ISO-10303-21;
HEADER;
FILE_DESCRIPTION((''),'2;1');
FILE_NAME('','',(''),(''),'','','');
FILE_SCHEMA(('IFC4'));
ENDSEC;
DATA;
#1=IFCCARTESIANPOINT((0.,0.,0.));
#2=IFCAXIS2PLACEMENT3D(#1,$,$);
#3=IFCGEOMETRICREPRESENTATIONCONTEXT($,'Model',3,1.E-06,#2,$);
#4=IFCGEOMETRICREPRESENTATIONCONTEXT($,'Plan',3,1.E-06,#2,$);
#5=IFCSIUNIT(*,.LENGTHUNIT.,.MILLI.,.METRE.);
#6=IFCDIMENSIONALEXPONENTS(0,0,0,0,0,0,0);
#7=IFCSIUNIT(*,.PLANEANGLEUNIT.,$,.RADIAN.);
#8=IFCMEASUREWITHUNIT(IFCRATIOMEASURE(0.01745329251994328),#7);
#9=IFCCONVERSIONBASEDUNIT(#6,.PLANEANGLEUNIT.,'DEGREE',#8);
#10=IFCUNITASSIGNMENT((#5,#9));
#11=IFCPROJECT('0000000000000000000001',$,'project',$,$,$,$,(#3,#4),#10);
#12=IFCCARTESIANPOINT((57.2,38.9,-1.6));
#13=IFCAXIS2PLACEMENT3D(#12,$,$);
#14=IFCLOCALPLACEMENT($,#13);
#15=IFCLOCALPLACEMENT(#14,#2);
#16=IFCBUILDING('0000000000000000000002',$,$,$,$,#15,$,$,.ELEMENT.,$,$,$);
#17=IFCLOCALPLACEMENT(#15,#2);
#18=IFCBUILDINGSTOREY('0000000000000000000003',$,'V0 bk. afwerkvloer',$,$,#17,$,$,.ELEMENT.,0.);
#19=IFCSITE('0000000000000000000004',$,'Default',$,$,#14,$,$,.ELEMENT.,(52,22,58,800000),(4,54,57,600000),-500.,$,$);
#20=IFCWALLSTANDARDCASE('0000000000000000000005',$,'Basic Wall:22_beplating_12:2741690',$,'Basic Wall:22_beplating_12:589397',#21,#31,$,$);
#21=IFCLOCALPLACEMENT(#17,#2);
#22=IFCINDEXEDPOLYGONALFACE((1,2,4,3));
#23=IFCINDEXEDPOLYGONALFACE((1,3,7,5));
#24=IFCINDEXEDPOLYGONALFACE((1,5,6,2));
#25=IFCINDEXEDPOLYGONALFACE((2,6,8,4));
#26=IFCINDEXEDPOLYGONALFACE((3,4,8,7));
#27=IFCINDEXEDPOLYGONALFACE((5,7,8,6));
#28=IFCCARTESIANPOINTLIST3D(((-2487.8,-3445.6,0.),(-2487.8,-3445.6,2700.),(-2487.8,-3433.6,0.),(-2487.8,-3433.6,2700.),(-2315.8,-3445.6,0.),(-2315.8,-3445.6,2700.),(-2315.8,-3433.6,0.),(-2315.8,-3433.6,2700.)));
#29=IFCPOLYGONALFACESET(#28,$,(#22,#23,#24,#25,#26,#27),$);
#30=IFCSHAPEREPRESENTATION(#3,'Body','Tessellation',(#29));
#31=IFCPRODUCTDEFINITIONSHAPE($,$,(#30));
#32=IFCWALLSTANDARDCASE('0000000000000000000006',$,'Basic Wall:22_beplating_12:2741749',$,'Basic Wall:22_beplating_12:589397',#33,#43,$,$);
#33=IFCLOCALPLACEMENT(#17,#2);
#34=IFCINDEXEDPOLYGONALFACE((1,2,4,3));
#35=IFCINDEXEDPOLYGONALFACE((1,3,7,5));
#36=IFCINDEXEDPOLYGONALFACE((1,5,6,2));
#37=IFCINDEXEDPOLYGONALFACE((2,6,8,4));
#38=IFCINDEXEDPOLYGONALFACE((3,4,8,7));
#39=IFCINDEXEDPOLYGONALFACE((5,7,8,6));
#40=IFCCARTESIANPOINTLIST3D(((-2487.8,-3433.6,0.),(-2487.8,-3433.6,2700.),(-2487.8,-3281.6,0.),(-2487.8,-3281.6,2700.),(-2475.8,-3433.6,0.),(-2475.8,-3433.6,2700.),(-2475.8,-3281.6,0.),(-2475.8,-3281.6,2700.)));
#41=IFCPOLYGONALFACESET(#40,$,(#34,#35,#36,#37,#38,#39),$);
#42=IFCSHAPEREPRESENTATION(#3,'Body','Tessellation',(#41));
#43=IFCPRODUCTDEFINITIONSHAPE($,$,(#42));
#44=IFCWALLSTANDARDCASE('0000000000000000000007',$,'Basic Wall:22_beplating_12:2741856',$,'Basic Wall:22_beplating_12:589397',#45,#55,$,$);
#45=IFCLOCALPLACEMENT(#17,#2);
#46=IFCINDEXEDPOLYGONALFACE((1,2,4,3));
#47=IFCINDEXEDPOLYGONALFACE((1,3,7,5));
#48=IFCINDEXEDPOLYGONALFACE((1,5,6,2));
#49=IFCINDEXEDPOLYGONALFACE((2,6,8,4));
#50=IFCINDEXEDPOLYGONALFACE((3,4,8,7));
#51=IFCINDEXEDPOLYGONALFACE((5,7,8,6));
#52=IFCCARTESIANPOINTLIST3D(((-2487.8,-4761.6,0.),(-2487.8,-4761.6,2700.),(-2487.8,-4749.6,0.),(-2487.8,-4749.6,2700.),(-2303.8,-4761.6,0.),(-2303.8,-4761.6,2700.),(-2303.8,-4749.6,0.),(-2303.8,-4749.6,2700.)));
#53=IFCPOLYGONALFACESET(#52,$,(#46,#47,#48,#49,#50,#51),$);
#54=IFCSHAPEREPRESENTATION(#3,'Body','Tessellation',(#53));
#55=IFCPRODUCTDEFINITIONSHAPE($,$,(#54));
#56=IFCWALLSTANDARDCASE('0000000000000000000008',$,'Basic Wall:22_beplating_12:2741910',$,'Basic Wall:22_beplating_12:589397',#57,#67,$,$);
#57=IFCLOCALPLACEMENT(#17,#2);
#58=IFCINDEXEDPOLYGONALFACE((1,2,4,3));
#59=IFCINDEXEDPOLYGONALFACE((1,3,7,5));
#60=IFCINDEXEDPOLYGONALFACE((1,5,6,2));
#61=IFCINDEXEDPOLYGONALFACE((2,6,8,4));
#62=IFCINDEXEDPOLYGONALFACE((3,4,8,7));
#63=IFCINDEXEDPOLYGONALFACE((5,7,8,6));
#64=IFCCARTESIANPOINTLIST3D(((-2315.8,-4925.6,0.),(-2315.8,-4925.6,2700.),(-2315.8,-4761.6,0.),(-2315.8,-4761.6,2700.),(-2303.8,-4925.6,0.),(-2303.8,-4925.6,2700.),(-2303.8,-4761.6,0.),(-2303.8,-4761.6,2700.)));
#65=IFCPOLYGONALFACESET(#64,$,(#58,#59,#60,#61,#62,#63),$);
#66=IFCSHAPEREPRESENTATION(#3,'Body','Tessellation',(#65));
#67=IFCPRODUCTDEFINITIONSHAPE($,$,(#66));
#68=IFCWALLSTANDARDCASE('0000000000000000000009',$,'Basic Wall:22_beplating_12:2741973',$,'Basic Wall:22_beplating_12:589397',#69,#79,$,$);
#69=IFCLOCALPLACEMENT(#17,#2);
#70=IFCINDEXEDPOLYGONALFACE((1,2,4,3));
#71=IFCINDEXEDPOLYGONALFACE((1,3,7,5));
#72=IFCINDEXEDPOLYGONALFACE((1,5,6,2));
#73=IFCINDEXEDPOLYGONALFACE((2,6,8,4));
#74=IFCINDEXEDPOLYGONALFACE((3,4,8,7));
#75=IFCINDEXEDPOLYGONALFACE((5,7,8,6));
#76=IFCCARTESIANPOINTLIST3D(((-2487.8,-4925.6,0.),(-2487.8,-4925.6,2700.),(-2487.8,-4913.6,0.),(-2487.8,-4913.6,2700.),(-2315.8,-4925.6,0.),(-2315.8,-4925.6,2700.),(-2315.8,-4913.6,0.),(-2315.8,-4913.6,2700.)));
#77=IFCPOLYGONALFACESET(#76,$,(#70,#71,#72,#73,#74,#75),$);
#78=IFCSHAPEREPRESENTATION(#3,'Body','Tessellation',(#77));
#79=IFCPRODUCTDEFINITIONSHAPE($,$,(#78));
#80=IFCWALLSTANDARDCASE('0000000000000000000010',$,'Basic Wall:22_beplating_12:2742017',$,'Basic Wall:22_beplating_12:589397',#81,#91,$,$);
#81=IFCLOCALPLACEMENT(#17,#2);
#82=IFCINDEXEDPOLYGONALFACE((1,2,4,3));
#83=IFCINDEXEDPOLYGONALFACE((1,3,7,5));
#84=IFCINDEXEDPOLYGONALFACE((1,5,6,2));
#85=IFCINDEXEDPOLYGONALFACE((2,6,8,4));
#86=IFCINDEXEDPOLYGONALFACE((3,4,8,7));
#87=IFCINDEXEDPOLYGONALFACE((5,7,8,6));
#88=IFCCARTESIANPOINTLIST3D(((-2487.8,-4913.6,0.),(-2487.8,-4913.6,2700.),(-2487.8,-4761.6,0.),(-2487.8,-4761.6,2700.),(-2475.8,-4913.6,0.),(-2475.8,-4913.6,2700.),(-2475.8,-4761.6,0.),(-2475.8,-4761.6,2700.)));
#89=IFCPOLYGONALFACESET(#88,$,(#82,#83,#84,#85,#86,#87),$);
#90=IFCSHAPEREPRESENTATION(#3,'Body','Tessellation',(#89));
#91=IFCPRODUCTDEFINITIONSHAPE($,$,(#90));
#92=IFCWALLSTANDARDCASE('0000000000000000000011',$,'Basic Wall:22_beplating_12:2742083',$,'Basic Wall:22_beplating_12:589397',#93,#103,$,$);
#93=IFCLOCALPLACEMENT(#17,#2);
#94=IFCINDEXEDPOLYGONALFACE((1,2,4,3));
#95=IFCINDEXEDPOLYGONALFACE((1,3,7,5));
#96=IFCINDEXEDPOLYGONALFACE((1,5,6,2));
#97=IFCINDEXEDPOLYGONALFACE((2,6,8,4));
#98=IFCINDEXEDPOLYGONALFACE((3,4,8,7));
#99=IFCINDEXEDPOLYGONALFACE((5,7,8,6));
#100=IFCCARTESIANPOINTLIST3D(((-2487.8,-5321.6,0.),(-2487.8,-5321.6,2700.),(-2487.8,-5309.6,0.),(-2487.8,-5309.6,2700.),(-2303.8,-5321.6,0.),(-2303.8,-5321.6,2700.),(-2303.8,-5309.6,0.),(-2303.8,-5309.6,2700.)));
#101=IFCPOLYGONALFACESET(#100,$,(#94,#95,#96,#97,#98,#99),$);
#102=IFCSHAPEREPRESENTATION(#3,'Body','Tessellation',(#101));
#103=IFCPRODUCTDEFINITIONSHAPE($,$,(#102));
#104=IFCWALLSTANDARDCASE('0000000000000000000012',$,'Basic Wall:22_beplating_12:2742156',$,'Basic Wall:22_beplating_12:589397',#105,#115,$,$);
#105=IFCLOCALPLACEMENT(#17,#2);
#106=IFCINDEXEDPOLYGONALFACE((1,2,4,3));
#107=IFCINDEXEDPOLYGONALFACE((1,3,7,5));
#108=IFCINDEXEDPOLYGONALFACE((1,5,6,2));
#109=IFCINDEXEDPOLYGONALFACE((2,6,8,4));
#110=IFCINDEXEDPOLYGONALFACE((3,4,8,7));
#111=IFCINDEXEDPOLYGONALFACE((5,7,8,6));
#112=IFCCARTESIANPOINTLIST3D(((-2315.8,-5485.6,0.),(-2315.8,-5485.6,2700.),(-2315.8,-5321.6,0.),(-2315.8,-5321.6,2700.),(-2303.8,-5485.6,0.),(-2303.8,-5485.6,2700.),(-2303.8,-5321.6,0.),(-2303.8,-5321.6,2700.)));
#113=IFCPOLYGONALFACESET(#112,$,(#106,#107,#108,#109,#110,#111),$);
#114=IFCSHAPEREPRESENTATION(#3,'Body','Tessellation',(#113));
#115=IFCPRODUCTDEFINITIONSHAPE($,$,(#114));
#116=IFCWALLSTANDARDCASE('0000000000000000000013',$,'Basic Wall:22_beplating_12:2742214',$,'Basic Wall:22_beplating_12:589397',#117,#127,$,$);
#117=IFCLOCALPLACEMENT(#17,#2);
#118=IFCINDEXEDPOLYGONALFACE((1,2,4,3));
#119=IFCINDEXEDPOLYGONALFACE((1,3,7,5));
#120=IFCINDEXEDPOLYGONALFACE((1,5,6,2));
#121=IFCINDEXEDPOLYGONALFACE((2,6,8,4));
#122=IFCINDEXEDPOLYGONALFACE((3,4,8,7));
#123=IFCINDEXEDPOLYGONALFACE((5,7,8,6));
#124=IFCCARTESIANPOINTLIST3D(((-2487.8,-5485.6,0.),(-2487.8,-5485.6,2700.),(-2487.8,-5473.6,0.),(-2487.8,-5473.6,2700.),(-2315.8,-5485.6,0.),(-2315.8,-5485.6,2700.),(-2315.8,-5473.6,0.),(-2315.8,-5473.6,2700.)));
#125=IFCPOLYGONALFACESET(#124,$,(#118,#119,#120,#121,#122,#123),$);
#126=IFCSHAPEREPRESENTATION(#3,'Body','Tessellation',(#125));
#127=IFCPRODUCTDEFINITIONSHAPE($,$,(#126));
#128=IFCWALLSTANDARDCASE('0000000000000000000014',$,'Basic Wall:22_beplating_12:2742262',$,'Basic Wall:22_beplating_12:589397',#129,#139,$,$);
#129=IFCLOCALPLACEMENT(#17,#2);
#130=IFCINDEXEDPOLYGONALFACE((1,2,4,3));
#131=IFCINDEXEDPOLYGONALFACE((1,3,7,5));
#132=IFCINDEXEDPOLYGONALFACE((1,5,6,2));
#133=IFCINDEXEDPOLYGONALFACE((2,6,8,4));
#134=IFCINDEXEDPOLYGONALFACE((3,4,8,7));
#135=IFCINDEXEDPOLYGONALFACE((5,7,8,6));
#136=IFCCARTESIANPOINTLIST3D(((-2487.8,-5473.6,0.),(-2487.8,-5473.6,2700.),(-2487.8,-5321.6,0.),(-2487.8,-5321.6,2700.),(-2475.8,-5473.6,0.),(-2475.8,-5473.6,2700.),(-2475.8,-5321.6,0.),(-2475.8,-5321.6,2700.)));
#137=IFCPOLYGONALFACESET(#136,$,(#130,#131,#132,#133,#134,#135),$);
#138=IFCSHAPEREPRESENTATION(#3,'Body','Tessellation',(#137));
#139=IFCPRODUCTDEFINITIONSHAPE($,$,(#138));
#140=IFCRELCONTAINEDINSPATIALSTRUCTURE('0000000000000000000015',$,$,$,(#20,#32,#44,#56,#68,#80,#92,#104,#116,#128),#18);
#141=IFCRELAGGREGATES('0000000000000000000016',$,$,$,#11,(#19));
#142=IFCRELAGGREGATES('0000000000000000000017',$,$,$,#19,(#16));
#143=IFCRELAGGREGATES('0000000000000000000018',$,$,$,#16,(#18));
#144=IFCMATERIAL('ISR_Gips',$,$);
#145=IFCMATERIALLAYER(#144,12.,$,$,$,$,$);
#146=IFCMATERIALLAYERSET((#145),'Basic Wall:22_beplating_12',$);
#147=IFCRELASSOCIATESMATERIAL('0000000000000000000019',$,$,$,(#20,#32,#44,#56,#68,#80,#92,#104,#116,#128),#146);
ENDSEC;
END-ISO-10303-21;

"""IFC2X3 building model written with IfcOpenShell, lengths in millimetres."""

from ifc_helpers import new_model, entity, si_unit, converted_unit, frame, frame_2d, origin, place, context, project, spatial, rectangle, extrude, material, layer, layer_set, layer_usage, element, save


model = new_model("IFC2X3")

# Units and contexts
model_context = context("Model", 3, precision=1e-06, world=origin())
plan_context = context("Plan", 3, precision=1e-06, world=origin())
ifc_project = project(units=[si_unit("LENGTHUNIT", "METRE", prefix="MILLI"), converted_unit("PLANEANGLEUNIT", "DEGREE", entity("IfcRatioMeasure", 0.01745329251994328), si_unit("PLANEANGLEUNIT", "RADIAN"), dimensions=[0, 0, 0, 0, 0, 0, 0])], contexts=[model_context, plan_context])

# Site, building, storey
site_placement = place(None, frame((57.2, 38.9, -1.6)))
site = spatial("IfcSite", under=ifc_project, at=site_placement, Name="Default", CompositionType="ELEMENT", RefLatitude=(52, 22, 58, 800000), RefLongitude=(4, 54, 57, 600000), RefElevation=-500.0)
building_placement = place(site_placement, origin())
building = spatial("IfcBuilding", under=site, at=building_placement, CompositionType="ELEMENT")
storey_placement = place(building_placement, origin())
storey = spatial("IfcBuildingStorey", under=building, at=storey_placement, Name="V0 bk. afwerkvloer", CompositionType="ELEMENT", Elevation=0.0)

# Walls
ifc_material_1 = material(Name="ISR_Gips")
ifc_layer_1 = layer(ifc_material_1, 12.0)
ifc_layer_set_1 = layer_set([ifc_layer_1], Name="Basic Wall:22_beplating_12")
ifc_layer_usage_1 = layer_usage(ifc_layer_set_1, "AXIS2", "POSITIVE", -6.0)
wall_1_placement = place(storey_placement, frame((-2315.8, -3439.6, 0.0), z_axis=(0.0, 0.0, 1.0), x_axis=(-1.0, 0.0, 0.0)))
element("IfcWallStandardCase", 1, at=wall_1_placement, inside=storey, material=ifc_layer_usage_1, Name="Basic Wall:22_beplating_12:2741690", ObjectType="Basic Wall:22_beplating_12:589397", context=model_context, shape_type="SweptSolid", body=[
    extrude(rectangle(XDim=172.0, YDim=12.0, at=frame_2d((86.0, 0.0), x_axis=(-1.0, 0.0))), origin(), (0.0, 0.0, 1.0), 2700.0),
])
ifc_layer_usage_2 = layer_usage(ifc_layer_set_1, "AXIS2", "POSITIVE", -6.0)
wall_2_placement = place(storey_placement, frame((-2481.8, -3433.6, 0.0), z_axis=(0.0, 0.0, 1.0), x_axis=(0.0, 1.0, 0.0)))
element("IfcWallStandardCase", 2, at=wall_2_placement, inside=storey, material=ifc_layer_usage_2, Name="Basic Wall:22_beplating_12:2741749", ObjectType="Basic Wall:22_beplating_12:589397", context=model_context, shape_type="SweptSolid", body=[
    extrude(rectangle(XDim=152.0, YDim=12.0, at=frame_2d((76.0, 0.0), x_axis=(-1.0, 0.0))), origin(), (0.0, 0.0, 1.0), 2700.0),
])
ifc_layer_usage_3 = layer_usage(ifc_layer_set_1, "AXIS2", "POSITIVE", -6.0)
wall_3_placement = place(storey_placement, frame((-2487.8, -4755.6, 0.0)))
element("IfcWallStandardCase", 3, at=wall_3_placement, inside=storey, material=ifc_layer_usage_3, Name="Basic Wall:22_beplating_12:2741856", ObjectType="Basic Wall:22_beplating_12:589397", context=model_context, shape_type="SweptSolid", body=[
    extrude(rectangle(XDim=184.0, YDim=12.0, at=frame_2d((92.0, 0.0), x_axis=(-1.0, 0.0))), origin(), (0.0, 0.0, 1.0), 2700.0),
])
ifc_layer_usage_4 = layer_usage(ifc_layer_set_1, "AXIS2", "POSITIVE", -6.0)
wall_4_placement = place(storey_placement, frame((-2309.8, -4761.6, 0.0), z_axis=(0.0, 0.0, 1.0), x_axis=(0.0, -1.0, 0.0)))
element("IfcWallStandardCase", 4, at=wall_4_placement, inside=storey, material=ifc_layer_usage_4, Name="Basic Wall:22_beplating_12:2741910", ObjectType="Basic Wall:22_beplating_12:589397", context=model_context, shape_type="SweptSolid", body=[
    extrude(rectangle(XDim=164.0, YDim=12.0, at=frame_2d((82.0, 0.0), x_axis=(-1.0, 0.0))), origin(), (0.0, 0.0, 1.0), 2700.0),
])
ifc_layer_usage_5 = layer_usage(ifc_layer_set_1, "AXIS2", "POSITIVE", -6.0)
wall_5_placement = place(storey_placement, frame((-2315.8, -4919.6, 0.0), z_axis=(0.0, 0.0, 1.0), x_axis=(-1.0, 0.0, 0.0)))
element("IfcWallStandardCase", 5, at=wall_5_placement, inside=storey, material=ifc_layer_usage_5, Name="Basic Wall:22_beplating_12:2741973", ObjectType="Basic Wall:22_beplating_12:589397", context=model_context, shape_type="SweptSolid", body=[
    extrude(rectangle(XDim=172.0, YDim=12.0, at=frame_2d((86.0, 0.0), x_axis=(-1.0, 0.0))), origin(), (0.0, 0.0, 1.0), 2700.0),
])
ifc_layer_usage_6 = layer_usage(ifc_layer_set_1, "AXIS2", "POSITIVE", -6.0)
wall_6_placement = place(storey_placement, frame((-2481.8, -4913.6, 0.0), z_axis=(0.0, 0.0, 1.0), x_axis=(0.0, 1.0, 0.0)))
element("IfcWallStandardCase", 6, at=wall_6_placement, inside=storey, material=ifc_layer_usage_6, Name="Basic Wall:22_beplating_12:2742017", ObjectType="Basic Wall:22_beplating_12:589397", context=model_context, shape_type="SweptSolid", body=[
    extrude(rectangle(XDim=152.0, YDim=12.0, at=frame_2d((76.0, 0.0), x_axis=(-1.0, 0.0))), origin(), (0.0, 0.0, 1.0), 2700.0),
])
ifc_layer_usage_7 = layer_usage(ifc_layer_set_1, "AXIS2", "POSITIVE", -6.0)
wall_7_placement = place(storey_placement, frame((-2487.8, -5315.6, 0.0)))
element("IfcWallStandardCase", 7, at=wall_7_placement, inside=storey, material=ifc_layer_usage_7, Name="Basic Wall:22_beplating_12:2742083", ObjectType="Basic Wall:22_beplating_12:589397", context=model_context, shape_type="SweptSolid", body=[
    extrude(rectangle(XDim=184.0, YDim=12.0, at=frame_2d((92.0, 0.0), x_axis=(-1.0, 0.0))), origin(), (0.0, 0.0, 1.0), 2700.0),
])
ifc_layer_usage_8 = layer_usage(ifc_layer_set_1, "AXIS2", "POSITIVE", -6.0)
wall_8_placement = place(storey_placement, frame((-2309.8, -5321.6, 0.0), z_axis=(0.0, 0.0, 1.0), x_axis=(0.0, -1.0, 0.0)))
element("IfcWallStandardCase", 8, at=wall_8_placement, inside=storey, material=ifc_layer_usage_8, Name="Basic Wall:22_beplating_12:2742156", ObjectType="Basic Wall:22_beplating_12:589397", context=model_context, shape_type="SweptSolid", body=[
    extrude(rectangle(XDim=164.0, YDim=12.0, at=frame_2d((82.0, 0.0), x_axis=(-1.0, 0.0))), origin(), (0.0, 0.0, 1.0), 2700.0),
])
ifc_layer_usage_9 = layer_usage(ifc_layer_set_1, "AXIS2", "POSITIVE", -6.0)
wall_9_placement = place(storey_placement, frame((-2315.8, -5479.6, 0.0), z_axis=(0.0, 0.0, 1.0), x_axis=(-1.0, 0.0, 0.0)))
element("IfcWallStandardCase", 9, at=wall_9_placement, inside=storey, material=ifc_layer_usage_9, Name="Basic Wall:22_beplating_12:2742214", ObjectType="Basic Wall:22_beplating_12:589397", context=model_context, shape_type="SweptSolid", body=[
    extrude(rectangle(XDim=172.0, YDim=12.0, at=frame_2d((86.0, 0.0), x_axis=(-1.0, 0.0))), origin(), (0.0, 0.0, 1.0), 2700.0),
])
ifc_layer_usage_10 = layer_usage(ifc_layer_set_1, "AXIS2", "POSITIVE", -6.0)
wall_10_placement = place(storey_placement, frame((-2481.8, -5473.6, 0.0), z_axis=(0.0, 0.0, 1.0), x_axis=(0.0, 1.0, 0.0)))
element("IfcWallStandardCase", 10, at=wall_10_placement, inside=storey, material=ifc_layer_usage_10, Name="Basic Wall:22_beplating_12:2742262", ObjectType="Basic Wall:22_beplating_12:589397", context=model_context, shape_type="SweptSolid", body=[
    extrude(rectangle(XDim=152.0, YDim=12.0, at=frame_2d((76.0, 0.0), x_axis=(-1.0, 0.0))), origin(), (0.0, 0.0, 1.0), 2700.0),
])

save(model, "model.ifc")
